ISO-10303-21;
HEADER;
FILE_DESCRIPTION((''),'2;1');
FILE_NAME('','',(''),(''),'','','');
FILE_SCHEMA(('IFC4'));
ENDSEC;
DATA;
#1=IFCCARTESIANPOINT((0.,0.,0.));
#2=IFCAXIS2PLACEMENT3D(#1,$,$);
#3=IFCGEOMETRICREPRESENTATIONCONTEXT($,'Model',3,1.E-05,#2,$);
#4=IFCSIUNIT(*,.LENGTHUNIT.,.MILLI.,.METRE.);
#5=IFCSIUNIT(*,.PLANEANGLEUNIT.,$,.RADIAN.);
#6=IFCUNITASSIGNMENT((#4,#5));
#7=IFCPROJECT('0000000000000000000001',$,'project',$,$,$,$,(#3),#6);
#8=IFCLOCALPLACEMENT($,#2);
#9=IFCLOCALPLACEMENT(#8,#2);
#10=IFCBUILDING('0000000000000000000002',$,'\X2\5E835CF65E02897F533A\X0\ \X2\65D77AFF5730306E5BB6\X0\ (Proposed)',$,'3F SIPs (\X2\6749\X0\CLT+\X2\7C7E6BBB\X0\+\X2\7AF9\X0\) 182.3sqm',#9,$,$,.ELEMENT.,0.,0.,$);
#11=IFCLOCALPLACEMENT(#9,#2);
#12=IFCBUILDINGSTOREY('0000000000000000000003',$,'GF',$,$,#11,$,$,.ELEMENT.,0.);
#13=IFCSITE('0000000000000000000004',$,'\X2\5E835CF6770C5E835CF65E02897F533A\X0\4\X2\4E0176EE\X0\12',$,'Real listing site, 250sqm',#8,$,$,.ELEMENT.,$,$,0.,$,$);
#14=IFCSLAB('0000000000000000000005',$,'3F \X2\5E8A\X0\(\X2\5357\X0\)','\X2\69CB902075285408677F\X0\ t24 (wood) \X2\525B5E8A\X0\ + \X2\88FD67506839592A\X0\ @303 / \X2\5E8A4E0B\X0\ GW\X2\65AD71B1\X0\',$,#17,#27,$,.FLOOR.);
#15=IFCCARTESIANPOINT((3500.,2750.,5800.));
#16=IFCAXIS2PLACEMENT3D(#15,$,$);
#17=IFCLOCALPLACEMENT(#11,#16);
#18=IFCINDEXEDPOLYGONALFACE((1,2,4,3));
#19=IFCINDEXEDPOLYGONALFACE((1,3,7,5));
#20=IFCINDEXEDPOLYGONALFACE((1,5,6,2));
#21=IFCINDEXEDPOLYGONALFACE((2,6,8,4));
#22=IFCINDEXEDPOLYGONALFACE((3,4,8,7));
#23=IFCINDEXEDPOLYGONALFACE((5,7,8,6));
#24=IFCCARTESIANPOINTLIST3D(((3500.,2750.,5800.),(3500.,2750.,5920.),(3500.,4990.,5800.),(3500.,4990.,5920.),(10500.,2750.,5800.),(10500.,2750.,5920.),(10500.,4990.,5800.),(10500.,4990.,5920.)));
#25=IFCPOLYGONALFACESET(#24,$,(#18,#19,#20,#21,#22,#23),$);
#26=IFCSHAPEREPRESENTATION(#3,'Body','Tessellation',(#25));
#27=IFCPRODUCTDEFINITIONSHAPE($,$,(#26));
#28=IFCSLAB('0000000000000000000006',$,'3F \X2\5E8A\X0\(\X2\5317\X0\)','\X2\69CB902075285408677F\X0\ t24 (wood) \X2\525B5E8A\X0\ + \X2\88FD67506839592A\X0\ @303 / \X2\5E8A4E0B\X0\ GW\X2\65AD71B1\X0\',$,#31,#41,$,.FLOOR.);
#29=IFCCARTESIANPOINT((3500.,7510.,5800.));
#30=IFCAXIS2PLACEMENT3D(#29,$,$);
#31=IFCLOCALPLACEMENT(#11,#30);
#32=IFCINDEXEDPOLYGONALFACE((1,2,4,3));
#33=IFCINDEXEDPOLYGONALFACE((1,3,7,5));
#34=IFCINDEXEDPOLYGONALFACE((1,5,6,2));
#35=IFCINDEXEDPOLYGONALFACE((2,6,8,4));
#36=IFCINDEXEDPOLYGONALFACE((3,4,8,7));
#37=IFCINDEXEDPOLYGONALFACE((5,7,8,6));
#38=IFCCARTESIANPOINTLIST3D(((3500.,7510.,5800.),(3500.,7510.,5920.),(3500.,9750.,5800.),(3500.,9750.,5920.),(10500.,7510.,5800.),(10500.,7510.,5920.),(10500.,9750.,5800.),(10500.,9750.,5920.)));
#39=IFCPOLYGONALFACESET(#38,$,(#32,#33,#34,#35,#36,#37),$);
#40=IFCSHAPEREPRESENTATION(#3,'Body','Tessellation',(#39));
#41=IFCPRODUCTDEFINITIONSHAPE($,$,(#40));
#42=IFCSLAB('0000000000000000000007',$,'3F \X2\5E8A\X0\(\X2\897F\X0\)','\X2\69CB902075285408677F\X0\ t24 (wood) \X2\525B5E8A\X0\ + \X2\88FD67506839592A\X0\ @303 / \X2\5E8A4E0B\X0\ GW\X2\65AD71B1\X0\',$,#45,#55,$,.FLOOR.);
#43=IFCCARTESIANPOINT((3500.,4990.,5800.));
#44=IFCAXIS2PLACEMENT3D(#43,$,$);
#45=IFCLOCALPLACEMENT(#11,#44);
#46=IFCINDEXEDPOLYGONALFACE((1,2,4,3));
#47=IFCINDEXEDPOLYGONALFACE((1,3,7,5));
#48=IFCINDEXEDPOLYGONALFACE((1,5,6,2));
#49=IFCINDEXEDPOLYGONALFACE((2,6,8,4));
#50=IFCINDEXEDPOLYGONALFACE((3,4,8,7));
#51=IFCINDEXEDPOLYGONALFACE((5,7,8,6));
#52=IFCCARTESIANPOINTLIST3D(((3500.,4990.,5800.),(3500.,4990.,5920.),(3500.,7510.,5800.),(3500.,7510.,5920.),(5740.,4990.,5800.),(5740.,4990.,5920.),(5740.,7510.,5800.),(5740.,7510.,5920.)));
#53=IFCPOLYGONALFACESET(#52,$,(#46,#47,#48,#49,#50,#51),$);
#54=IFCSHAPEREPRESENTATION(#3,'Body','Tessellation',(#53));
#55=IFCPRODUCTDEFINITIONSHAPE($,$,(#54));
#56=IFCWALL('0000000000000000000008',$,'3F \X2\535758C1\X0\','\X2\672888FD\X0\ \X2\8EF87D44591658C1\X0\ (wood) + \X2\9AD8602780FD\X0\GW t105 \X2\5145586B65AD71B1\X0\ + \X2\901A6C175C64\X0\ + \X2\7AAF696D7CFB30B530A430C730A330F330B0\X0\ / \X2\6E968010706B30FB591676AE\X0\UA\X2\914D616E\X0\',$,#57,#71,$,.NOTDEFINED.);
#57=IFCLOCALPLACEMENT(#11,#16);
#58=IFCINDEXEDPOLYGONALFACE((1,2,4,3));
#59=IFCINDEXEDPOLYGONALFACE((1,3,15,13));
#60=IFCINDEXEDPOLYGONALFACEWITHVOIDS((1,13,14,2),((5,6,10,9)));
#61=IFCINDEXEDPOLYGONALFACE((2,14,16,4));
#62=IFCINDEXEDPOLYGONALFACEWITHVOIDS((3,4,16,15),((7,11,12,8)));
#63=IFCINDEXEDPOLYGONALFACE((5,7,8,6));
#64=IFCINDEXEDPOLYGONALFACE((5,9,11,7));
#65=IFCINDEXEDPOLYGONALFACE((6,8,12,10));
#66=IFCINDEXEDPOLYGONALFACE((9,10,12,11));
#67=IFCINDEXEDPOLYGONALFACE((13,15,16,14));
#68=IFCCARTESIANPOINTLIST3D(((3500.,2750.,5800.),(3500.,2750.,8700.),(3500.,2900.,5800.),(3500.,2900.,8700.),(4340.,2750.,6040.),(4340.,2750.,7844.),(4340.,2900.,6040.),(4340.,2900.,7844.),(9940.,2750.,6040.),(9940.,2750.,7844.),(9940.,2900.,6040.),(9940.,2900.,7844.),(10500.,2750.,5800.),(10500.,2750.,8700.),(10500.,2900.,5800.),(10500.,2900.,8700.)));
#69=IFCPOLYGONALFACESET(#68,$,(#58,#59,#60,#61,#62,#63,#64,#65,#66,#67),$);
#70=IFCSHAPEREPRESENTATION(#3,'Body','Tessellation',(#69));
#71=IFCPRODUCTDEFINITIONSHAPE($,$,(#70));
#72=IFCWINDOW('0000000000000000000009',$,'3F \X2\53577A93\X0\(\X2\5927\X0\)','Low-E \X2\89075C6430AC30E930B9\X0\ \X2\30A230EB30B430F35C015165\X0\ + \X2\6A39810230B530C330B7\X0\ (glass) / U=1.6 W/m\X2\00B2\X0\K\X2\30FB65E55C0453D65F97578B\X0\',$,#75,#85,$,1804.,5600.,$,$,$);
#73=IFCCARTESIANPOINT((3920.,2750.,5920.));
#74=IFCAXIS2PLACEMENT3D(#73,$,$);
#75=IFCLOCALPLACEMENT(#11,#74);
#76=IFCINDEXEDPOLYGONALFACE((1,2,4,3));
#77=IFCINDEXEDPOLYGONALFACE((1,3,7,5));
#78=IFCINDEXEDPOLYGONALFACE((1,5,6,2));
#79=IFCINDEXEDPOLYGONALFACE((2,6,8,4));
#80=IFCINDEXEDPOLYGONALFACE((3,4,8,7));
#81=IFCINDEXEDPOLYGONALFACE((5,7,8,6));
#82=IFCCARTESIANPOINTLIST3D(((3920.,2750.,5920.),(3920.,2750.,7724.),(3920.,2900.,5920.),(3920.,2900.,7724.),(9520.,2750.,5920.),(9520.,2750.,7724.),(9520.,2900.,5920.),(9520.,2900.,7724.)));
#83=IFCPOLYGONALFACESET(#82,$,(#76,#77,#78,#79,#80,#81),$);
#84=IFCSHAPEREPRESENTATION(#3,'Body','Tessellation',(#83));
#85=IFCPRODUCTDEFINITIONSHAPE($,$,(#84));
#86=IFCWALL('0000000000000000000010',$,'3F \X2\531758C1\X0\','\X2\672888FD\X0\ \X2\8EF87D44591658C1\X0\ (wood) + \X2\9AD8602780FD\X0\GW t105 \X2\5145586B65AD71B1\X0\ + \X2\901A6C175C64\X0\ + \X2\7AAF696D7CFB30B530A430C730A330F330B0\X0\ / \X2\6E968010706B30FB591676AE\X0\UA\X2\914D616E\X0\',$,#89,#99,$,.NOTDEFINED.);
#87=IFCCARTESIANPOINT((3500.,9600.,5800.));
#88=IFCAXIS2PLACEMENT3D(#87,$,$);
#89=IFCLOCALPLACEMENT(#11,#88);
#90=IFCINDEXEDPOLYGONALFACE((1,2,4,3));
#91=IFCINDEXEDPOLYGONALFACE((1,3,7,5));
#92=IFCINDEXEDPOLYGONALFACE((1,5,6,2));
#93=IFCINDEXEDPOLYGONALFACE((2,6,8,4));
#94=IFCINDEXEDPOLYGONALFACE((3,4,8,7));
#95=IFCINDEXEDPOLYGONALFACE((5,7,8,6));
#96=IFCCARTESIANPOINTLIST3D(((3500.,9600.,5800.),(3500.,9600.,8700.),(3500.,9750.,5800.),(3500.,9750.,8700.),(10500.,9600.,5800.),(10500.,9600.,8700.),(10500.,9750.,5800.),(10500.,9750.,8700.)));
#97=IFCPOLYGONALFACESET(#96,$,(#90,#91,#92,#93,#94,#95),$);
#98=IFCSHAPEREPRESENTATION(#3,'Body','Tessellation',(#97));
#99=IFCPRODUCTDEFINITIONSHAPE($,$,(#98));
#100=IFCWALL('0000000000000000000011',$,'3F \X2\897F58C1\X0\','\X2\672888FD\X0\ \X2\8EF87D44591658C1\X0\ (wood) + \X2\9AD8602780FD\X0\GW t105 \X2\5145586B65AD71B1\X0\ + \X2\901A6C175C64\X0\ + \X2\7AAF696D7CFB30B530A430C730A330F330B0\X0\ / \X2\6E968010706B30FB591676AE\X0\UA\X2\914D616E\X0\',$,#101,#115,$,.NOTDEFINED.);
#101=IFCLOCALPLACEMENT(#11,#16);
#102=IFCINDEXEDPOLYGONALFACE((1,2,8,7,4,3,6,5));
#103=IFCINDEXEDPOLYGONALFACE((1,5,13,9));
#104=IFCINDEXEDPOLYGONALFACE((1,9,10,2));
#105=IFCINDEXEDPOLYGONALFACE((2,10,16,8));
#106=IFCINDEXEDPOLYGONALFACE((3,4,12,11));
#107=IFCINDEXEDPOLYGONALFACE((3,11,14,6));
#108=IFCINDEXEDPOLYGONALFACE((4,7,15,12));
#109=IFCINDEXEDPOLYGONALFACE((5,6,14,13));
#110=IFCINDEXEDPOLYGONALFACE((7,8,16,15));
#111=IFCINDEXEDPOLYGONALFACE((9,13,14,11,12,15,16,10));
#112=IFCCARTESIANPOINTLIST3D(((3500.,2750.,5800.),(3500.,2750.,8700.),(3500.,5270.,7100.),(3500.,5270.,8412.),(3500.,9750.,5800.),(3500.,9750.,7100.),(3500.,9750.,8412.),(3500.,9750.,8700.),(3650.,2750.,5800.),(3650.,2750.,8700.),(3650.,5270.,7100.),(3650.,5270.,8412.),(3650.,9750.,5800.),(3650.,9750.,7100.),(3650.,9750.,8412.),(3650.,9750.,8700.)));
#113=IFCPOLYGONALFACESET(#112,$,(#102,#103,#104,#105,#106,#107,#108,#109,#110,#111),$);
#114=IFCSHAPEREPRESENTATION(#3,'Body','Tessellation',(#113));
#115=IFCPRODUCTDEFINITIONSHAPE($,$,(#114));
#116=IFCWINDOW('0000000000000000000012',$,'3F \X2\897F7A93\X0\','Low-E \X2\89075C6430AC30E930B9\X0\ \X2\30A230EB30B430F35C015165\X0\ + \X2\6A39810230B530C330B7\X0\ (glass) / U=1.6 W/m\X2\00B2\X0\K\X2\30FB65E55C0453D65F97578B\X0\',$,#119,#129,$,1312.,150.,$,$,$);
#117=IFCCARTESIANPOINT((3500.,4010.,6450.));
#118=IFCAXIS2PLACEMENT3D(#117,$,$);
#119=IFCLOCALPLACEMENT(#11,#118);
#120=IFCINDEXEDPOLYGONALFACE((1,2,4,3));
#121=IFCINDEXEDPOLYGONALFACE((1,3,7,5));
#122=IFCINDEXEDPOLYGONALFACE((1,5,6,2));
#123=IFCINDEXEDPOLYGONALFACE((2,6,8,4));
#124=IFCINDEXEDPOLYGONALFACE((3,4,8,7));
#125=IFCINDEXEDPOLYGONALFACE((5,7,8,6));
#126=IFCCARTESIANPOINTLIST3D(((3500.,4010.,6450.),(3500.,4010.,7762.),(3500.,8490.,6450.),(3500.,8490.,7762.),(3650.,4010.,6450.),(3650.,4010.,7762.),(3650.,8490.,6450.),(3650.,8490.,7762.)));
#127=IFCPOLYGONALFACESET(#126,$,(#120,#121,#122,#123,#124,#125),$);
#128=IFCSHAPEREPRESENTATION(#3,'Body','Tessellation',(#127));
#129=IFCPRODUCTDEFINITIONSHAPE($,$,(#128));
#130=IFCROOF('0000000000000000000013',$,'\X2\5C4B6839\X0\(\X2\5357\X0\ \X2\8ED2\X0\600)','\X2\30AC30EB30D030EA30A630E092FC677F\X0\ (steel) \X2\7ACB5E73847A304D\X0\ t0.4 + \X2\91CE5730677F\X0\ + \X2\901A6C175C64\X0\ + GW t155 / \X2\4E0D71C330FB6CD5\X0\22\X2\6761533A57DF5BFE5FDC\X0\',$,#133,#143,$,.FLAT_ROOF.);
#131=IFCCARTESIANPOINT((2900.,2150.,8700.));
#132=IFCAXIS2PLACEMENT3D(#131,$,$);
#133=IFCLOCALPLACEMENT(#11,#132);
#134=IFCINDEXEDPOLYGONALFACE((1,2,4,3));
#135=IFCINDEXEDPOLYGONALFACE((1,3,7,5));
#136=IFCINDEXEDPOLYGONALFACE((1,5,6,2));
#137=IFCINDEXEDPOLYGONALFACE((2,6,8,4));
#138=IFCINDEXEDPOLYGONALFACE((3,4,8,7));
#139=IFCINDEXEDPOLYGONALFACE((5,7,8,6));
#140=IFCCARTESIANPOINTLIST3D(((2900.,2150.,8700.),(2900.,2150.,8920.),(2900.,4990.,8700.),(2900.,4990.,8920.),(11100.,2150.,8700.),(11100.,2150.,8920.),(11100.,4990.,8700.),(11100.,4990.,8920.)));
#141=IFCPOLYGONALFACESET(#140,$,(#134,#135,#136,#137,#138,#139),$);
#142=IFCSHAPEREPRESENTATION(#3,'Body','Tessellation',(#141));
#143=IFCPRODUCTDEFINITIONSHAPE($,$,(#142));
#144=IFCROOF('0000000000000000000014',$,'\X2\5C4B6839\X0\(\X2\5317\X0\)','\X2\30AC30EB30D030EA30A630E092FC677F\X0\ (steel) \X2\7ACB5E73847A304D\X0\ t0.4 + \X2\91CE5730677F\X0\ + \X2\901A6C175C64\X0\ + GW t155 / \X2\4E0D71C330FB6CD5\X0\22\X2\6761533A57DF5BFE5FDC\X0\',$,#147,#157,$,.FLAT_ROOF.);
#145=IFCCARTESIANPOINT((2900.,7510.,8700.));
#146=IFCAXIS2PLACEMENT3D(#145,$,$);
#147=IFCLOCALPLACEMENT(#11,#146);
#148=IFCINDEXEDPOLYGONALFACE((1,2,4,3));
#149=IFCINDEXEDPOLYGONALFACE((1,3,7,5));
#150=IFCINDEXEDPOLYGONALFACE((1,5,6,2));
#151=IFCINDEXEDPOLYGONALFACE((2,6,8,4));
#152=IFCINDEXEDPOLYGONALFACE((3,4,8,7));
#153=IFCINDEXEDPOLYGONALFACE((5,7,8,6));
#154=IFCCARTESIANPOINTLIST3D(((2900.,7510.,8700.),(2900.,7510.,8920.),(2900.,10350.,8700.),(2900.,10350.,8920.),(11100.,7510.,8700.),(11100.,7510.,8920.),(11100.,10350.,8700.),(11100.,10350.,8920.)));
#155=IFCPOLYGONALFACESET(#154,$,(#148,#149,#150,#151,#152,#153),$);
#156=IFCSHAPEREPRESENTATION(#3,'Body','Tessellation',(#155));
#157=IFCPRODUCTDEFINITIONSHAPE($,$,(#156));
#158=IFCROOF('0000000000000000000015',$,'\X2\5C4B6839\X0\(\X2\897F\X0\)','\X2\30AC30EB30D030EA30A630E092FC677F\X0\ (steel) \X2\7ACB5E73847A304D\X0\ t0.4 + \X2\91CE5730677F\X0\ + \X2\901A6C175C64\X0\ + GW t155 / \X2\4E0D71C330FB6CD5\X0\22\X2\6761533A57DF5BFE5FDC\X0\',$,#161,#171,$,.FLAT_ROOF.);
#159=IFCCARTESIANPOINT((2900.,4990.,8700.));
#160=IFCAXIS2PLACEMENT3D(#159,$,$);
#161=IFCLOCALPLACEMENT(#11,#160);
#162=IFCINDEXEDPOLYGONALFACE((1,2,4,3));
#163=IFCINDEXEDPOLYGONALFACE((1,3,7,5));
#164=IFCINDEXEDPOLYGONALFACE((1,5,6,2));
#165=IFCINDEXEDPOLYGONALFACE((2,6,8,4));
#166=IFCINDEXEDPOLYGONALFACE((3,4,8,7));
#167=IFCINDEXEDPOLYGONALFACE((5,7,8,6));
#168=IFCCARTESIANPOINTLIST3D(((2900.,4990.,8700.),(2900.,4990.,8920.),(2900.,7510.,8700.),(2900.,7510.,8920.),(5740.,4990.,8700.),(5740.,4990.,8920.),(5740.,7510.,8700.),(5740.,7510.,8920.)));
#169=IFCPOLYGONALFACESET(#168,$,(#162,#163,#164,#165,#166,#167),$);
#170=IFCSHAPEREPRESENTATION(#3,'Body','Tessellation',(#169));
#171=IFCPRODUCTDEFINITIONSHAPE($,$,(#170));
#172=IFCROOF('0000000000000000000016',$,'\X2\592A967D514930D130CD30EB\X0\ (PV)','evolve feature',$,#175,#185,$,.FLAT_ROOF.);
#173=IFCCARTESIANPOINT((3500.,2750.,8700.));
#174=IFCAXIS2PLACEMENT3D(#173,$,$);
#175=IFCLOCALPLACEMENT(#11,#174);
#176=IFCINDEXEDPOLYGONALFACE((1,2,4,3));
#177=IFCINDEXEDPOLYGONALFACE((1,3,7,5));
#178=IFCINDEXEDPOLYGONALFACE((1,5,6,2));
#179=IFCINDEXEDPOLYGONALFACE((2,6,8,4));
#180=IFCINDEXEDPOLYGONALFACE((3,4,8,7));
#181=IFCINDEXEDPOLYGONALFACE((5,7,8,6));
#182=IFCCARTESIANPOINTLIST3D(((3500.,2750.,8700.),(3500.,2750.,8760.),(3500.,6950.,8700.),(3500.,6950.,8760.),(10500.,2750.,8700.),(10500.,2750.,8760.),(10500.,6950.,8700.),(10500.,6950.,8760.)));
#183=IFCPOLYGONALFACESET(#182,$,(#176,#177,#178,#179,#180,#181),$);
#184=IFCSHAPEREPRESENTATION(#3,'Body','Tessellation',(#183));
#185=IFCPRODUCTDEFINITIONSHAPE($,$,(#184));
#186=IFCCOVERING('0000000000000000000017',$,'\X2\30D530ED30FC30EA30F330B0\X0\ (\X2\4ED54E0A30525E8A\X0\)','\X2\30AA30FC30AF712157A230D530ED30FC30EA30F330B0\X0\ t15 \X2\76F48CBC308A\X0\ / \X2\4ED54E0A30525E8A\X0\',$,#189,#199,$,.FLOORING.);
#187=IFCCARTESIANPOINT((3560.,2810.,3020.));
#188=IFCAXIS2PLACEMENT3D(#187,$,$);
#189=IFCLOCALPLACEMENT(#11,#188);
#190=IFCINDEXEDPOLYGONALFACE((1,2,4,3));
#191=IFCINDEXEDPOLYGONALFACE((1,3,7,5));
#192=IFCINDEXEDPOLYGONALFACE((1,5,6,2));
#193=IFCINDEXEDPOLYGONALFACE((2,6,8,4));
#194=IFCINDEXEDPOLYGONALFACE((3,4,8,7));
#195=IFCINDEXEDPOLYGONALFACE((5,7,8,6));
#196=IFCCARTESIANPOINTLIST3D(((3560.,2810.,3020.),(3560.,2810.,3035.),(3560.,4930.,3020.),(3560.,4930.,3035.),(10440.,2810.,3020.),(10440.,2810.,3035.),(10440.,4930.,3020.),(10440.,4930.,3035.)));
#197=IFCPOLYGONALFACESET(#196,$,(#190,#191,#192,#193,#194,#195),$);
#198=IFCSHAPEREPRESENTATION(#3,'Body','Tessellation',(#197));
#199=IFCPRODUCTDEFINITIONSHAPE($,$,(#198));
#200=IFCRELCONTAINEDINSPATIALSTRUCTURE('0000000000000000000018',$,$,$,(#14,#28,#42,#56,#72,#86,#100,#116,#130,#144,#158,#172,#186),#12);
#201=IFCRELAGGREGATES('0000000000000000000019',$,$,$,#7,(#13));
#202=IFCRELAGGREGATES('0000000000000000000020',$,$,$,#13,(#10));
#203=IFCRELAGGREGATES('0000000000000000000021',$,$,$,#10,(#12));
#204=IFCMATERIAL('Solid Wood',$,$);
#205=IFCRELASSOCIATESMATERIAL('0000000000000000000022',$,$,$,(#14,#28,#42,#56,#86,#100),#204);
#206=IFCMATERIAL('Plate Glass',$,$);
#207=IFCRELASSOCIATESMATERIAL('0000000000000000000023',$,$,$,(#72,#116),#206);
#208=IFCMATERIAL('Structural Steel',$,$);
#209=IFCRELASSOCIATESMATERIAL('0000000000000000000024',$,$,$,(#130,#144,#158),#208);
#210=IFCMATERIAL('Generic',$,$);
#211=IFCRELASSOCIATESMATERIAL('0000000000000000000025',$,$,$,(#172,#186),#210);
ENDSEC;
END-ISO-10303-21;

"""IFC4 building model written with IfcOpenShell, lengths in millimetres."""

from ifc_helpers import new_model, si_unit, frame, frame_2d, origin, place, context, project, spatial, rectangle, extrude, material, element, fill, save


model = new_model("IFC4")

# Units and contexts
model_context = context("Model", 3, precision=1e-05, world=origin())
ifc_project = project(units=[si_unit("LENGTHUNIT", "METRE", prefix="MILLI"), si_unit("PLANEANGLEUNIT", "RADIAN")], contexts=[model_context])

# Site, building, storey
site_placement = place(None, origin())
site = spatial("IfcSite", under=ifc_project, at=site_placement, Name="広島県広島市西区4丁目12", ObjectType="Real listing site, 250sqm", CompositionType="ELEMENT", RefElevation=0.0)
building_placement = place(site_placement, origin())
building = spatial("IfcBuilding", under=site, at=building_placement, Name="広島市西区 旗竿地の家 (Proposed)", ObjectType="3F SIPs (杉CLT+籾殻+竹) 182.3sqm", CompositionType="ELEMENT", ElevationOfRefHeight=0.0, ElevationOfTerrain=0.0)
storey_placement = place(building_placement, origin())
storey = spatial("IfcBuildingStorey", under=building, at=storey_placement, Name="GF", CompositionType="ELEMENT", Elevation=0.0)

# Slabs
ifc_material_1 = material(Name="Solid Wood")
slab_1_placement = place(storey_placement, frame((3500.0, 2750.0, 5800.0)))
element("IfcSlab", 1, at=slab_1_placement, inside=storey, material=ifc_material_1, Name="3F 床(南)", Description="構造用合板 t24 (wood) 剛床 + 製材根太 @303 / 床下 GW断熱", PredefinedType="FLOOR", context=model_context, shape_type="SweptSolid", body=[
    extrude(rectangle(XDim=7000.0, YDim=2240.0, at=frame_2d((3500.0, 1120.0))), frame((3500.0, 2750.0, 5800.0)), (0.0, 0.0, 1.0), 120.0),
])
slab_2_placement = place(storey_placement, frame((3500.0, 7510.0, 5800.0)))
element("IfcSlab", 2, at=slab_2_placement, inside=storey, material=ifc_material_1, Name="3F 床(北)", Description="構造用合板 t24 (wood) 剛床 + 製材根太 @303 / 床下 GW断熱", PredefinedType="FLOOR", context=model_context, shape_type="SweptSolid", body=[
    extrude(rectangle(XDim=7000.0, YDim=2240.0, at=frame_2d((3500.0, 1120.0))), frame((3500.0, 7510.0, 5800.0)), (0.0, 0.0, 1.0), 120.0),
])
slab_3_placement = place(storey_placement, frame((3500.0, 4990.0, 5800.0)))
element("IfcSlab", 3, at=slab_3_placement, inside=storey, material=ifc_material_1, Name="3F 床(西)", Description="構造用合板 t24 (wood) 剛床 + 製材根太 @303 / 床下 GW断熱", PredefinedType="FLOOR", context=model_context, shape_type="SweptSolid", body=[
    extrude(rectangle(XDim=2240.0, YDim=2520.0, at=frame_2d((1120.0, 1260.0))), frame((3500.0, 4990.0, 5800.0)), (0.0, 0.0, 1.0), 120.0),
])

# Wall, opening, window
wall_1_placement = place(storey_placement, frame((3500.0, 2750.0, 5800.0)))
wall_1 = element("IfcWall", 4, at=wall_1_placement, inside=storey, material=ifc_material_1, Name="3F 南壁", Description="木製 軸組外壁 (wood) + 高性能GW t105 充填断熱 + 通気層 + 窯業系サイディング / 準耐火・外皮UA配慮", PredefinedType="NOTDEFINED", context=model_context, shape_type="SweptSolid", body=[
    extrude(rectangle(XDim=7000.0, YDim=150.0, at=frame_2d((3500.0, 75.0))), frame((3500.0, 2750.0, 5800.0)), (0.0, 0.0, 1.0), 2900.0),
])
opening_1_placement = place(storey_placement, frame((3920.0, 2750.0, 5920.0)))
opening_1 = element("IfcOpeningElement", 5, at=opening_1_placement, cuts=wall_1, PredefinedType="NOTDEFINED", context=model_context, shape_type="SweptSolid", body=[
    extrude(rectangle(XDim=5600.0, YDim=150.0, at=frame_2d((2800.0, 75.0))), frame((3920.0, 2750.0, 5920.0)), (0.0, 0.0, 1.0), 1804.0),
])
ifc_material_2 = material(Name="Plate Glass")
window_1_placement = place(storey_placement, frame((3920.0, 2750.0, 5920.0)))
window_1 = element("IfcWindow", 6, at=window_1_placement, inside=storey, material=ifc_material_2, Name="3F 南窓(大)", Description="Low-E 複層ガラス アルゴン封入 + 樹脂サッシ (glass) / U=1.6 W/m²K・日射取得型", OverallHeight=1804.0, OverallWidth=5600.0, context=model_context, shape_type="SweptSolid", body=[
    extrude(rectangle(XDim=5600.0, YDim=150.0, at=frame_2d((2800.0, 75.0))), frame((3920.0, 2750.0, 5920.0)), (0.0, 0.0, 1.0), 1804.0),
])
fill(opening_1, window_1)

# Wall
wall_2_placement = place(storey_placement, frame((3500.0, 9600.0, 5800.0)))
element("IfcWall", 7, at=wall_2_placement, inside=storey, material=ifc_material_1, Name="3F 北壁", Description="木製 軸組外壁 (wood) + 高性能GW t105 充填断熱 + 通気層 + 窯業系サイディング / 準耐火・外皮UA配慮", PredefinedType="NOTDEFINED", context=model_context, shape_type="SweptSolid", body=[
    extrude(rectangle(XDim=7000.0, YDim=150.0, at=frame_2d((3500.0, 75.0))), frame((3500.0, 9600.0, 5800.0)), (0.0, 0.0, 1.0), 2900.0),
])

# Wall, opening, window
wall_3_placement = place(storey_placement, frame((3500.0, 2750.0, 5800.0)))
wall_3 = element("IfcWall", 8, at=wall_3_placement, inside=storey, material=ifc_material_1, Name="3F 西壁", Description="木製 軸組外壁 (wood) + 高性能GW t105 充填断熱 + 通気層 + 窯業系サイディング / 準耐火・外皮UA配慮", PredefinedType="NOTDEFINED", context=model_context, shape_type="SweptSolid", body=[
    extrude(rectangle(XDim=150.0, YDim=7000.0, at=frame_2d((75.0, 3500.0))), frame((3500.0, 2750.0, 5800.0)), (0.0, 0.0, 1.0), 2900.0),
])
opening_2_placement = place(storey_placement, frame((3500.0, 4010.0, 6450.0)))
opening_2 = element("IfcOpeningElement", 9, at=opening_2_placement, cuts=wall_3, PredefinedType="NOTDEFINED", context=model_context, shape_type="SweptSolid", body=[
    extrude(rectangle(XDim=150.0, YDim=4480.0, at=frame_2d((75.0, 2240.0))), frame((3500.0, 4010.0, 6450.0)), (0.0, 0.0, 1.0), 1312.0),
])
window_2_placement = place(storey_placement, frame((3500.0, 4010.0, 6450.0)))
window_2 = element("IfcWindow", 10, at=window_2_placement, inside=storey, material=ifc_material_2, Name="3F 西窓", Description="Low-E 複層ガラス アルゴン封入 + 樹脂サッシ (glass) / U=1.6 W/m²K・日射取得型", OverallHeight=1312.0, OverallWidth=150.0, context=model_context, shape_type="SweptSolid", body=[
    extrude(rectangle(XDim=150.0, YDim=4480.0, at=frame_2d((75.0, 2240.0))), frame((3500.0, 4010.0, 6450.0)), (0.0, 0.0, 1.0), 1312.0),
])
fill(opening_2, window_2)

# Roofs
ifc_material_3 = material(Name="Structural Steel")
roof_1_placement = place(storey_placement, frame((2900.0, 2150.0, 8700.0)))
element("IfcRoof", 11, at=roof_1_placement, inside=storey, material=ifc_material_3, Name="屋根(南 軒600)", Description="ガルバリウム鋼板 (steel) 立平葺き t0.4 + 野地板 + 通気層 + GW t155 / 不燃・法22条区域対応", PredefinedType="FLAT_ROOF", context=model_context, shape_type="SweptSolid", body=[
    extrude(rectangle(XDim=8200.0, YDim=2840.0, at=frame_2d((4100.0, 1420.0))), frame((2900.0, 2150.0, 8700.0)), (0.0, 0.0, 1.0), 220.0),
])
roof_2_placement = place(storey_placement, frame((2900.0, 7510.0, 8700.0)))
element("IfcRoof", 12, at=roof_2_placement, inside=storey, material=ifc_material_3, Name="屋根(北)", Description="ガルバリウム鋼板 (steel) 立平葺き t0.4 + 野地板 + 通気層 + GW t155 / 不燃・法22条区域対応", PredefinedType="FLAT_ROOF", context=model_context, shape_type="SweptSolid", body=[
    extrude(rectangle(XDim=8200.0, YDim=2840.0, at=frame_2d((4100.0, 1420.0))), frame((2900.0, 7510.0, 8700.0)), (0.0, 0.0, 1.0), 220.0),
])
roof_3_placement = place(storey_placement, frame((2900.0, 4990.0, 8700.0)))
element("IfcRoof", 13, at=roof_3_placement, inside=storey, material=ifc_material_3, Name="屋根(西)", Description="ガルバリウム鋼板 (steel) 立平葺き t0.4 + 野地板 + 通気層 + GW t155 / 不燃・法22条区域対応", PredefinedType="FLAT_ROOF", context=model_context, shape_type="SweptSolid", body=[
    extrude(rectangle(XDim=2840.0, YDim=2520.0, at=frame_2d((1420.0, 1260.0))), frame((2900.0, 4990.0, 8700.0)), (0.0, 0.0, 1.0), 220.0),
])
ifc_material_4 = material(Name="Generic")
roof_4_placement = place(storey_placement, frame((3500.0, 2750.0, 8700.0)))
element("IfcRoof", 14, at=roof_4_placement, inside=storey, material=ifc_material_4, Name="太陽光パネル (PV)", Description="evolve feature", PredefinedType="FLAT_ROOF", context=model_context, shape_type="SweptSolid", body=[
    extrude(rectangle(XDim=7000.0, YDim=4200.0, at=frame_2d((3500.0, 2100.0))), frame((3500.0, 2750.0, 8700.0)), (0.0, 0.0, 1.0), 60.0),
])

# Covering
covering_1_placement = place(storey_placement, frame((3560.0, 2810.0, 3020.0)))
element("IfcCovering", 15, at=covering_1_placement, inside=storey, material=ifc_material_4, Name="フローリング (仕上げ床)", Description="オーク無垢フローリング t15 直貼り / 仕上げ床", PredefinedType="FLOORING", context=model_context, shape_type="SweptSolid", body=[
    extrude(rectangle(XDim=6880.0, YDim=2120.0, at=frame_2d((3440.0, 1060.0))), frame((3560.0, 2810.0, 3020.0)), (0.0, 0.0, 1.0), 15.0),
])

save(model, "model.ifc")
